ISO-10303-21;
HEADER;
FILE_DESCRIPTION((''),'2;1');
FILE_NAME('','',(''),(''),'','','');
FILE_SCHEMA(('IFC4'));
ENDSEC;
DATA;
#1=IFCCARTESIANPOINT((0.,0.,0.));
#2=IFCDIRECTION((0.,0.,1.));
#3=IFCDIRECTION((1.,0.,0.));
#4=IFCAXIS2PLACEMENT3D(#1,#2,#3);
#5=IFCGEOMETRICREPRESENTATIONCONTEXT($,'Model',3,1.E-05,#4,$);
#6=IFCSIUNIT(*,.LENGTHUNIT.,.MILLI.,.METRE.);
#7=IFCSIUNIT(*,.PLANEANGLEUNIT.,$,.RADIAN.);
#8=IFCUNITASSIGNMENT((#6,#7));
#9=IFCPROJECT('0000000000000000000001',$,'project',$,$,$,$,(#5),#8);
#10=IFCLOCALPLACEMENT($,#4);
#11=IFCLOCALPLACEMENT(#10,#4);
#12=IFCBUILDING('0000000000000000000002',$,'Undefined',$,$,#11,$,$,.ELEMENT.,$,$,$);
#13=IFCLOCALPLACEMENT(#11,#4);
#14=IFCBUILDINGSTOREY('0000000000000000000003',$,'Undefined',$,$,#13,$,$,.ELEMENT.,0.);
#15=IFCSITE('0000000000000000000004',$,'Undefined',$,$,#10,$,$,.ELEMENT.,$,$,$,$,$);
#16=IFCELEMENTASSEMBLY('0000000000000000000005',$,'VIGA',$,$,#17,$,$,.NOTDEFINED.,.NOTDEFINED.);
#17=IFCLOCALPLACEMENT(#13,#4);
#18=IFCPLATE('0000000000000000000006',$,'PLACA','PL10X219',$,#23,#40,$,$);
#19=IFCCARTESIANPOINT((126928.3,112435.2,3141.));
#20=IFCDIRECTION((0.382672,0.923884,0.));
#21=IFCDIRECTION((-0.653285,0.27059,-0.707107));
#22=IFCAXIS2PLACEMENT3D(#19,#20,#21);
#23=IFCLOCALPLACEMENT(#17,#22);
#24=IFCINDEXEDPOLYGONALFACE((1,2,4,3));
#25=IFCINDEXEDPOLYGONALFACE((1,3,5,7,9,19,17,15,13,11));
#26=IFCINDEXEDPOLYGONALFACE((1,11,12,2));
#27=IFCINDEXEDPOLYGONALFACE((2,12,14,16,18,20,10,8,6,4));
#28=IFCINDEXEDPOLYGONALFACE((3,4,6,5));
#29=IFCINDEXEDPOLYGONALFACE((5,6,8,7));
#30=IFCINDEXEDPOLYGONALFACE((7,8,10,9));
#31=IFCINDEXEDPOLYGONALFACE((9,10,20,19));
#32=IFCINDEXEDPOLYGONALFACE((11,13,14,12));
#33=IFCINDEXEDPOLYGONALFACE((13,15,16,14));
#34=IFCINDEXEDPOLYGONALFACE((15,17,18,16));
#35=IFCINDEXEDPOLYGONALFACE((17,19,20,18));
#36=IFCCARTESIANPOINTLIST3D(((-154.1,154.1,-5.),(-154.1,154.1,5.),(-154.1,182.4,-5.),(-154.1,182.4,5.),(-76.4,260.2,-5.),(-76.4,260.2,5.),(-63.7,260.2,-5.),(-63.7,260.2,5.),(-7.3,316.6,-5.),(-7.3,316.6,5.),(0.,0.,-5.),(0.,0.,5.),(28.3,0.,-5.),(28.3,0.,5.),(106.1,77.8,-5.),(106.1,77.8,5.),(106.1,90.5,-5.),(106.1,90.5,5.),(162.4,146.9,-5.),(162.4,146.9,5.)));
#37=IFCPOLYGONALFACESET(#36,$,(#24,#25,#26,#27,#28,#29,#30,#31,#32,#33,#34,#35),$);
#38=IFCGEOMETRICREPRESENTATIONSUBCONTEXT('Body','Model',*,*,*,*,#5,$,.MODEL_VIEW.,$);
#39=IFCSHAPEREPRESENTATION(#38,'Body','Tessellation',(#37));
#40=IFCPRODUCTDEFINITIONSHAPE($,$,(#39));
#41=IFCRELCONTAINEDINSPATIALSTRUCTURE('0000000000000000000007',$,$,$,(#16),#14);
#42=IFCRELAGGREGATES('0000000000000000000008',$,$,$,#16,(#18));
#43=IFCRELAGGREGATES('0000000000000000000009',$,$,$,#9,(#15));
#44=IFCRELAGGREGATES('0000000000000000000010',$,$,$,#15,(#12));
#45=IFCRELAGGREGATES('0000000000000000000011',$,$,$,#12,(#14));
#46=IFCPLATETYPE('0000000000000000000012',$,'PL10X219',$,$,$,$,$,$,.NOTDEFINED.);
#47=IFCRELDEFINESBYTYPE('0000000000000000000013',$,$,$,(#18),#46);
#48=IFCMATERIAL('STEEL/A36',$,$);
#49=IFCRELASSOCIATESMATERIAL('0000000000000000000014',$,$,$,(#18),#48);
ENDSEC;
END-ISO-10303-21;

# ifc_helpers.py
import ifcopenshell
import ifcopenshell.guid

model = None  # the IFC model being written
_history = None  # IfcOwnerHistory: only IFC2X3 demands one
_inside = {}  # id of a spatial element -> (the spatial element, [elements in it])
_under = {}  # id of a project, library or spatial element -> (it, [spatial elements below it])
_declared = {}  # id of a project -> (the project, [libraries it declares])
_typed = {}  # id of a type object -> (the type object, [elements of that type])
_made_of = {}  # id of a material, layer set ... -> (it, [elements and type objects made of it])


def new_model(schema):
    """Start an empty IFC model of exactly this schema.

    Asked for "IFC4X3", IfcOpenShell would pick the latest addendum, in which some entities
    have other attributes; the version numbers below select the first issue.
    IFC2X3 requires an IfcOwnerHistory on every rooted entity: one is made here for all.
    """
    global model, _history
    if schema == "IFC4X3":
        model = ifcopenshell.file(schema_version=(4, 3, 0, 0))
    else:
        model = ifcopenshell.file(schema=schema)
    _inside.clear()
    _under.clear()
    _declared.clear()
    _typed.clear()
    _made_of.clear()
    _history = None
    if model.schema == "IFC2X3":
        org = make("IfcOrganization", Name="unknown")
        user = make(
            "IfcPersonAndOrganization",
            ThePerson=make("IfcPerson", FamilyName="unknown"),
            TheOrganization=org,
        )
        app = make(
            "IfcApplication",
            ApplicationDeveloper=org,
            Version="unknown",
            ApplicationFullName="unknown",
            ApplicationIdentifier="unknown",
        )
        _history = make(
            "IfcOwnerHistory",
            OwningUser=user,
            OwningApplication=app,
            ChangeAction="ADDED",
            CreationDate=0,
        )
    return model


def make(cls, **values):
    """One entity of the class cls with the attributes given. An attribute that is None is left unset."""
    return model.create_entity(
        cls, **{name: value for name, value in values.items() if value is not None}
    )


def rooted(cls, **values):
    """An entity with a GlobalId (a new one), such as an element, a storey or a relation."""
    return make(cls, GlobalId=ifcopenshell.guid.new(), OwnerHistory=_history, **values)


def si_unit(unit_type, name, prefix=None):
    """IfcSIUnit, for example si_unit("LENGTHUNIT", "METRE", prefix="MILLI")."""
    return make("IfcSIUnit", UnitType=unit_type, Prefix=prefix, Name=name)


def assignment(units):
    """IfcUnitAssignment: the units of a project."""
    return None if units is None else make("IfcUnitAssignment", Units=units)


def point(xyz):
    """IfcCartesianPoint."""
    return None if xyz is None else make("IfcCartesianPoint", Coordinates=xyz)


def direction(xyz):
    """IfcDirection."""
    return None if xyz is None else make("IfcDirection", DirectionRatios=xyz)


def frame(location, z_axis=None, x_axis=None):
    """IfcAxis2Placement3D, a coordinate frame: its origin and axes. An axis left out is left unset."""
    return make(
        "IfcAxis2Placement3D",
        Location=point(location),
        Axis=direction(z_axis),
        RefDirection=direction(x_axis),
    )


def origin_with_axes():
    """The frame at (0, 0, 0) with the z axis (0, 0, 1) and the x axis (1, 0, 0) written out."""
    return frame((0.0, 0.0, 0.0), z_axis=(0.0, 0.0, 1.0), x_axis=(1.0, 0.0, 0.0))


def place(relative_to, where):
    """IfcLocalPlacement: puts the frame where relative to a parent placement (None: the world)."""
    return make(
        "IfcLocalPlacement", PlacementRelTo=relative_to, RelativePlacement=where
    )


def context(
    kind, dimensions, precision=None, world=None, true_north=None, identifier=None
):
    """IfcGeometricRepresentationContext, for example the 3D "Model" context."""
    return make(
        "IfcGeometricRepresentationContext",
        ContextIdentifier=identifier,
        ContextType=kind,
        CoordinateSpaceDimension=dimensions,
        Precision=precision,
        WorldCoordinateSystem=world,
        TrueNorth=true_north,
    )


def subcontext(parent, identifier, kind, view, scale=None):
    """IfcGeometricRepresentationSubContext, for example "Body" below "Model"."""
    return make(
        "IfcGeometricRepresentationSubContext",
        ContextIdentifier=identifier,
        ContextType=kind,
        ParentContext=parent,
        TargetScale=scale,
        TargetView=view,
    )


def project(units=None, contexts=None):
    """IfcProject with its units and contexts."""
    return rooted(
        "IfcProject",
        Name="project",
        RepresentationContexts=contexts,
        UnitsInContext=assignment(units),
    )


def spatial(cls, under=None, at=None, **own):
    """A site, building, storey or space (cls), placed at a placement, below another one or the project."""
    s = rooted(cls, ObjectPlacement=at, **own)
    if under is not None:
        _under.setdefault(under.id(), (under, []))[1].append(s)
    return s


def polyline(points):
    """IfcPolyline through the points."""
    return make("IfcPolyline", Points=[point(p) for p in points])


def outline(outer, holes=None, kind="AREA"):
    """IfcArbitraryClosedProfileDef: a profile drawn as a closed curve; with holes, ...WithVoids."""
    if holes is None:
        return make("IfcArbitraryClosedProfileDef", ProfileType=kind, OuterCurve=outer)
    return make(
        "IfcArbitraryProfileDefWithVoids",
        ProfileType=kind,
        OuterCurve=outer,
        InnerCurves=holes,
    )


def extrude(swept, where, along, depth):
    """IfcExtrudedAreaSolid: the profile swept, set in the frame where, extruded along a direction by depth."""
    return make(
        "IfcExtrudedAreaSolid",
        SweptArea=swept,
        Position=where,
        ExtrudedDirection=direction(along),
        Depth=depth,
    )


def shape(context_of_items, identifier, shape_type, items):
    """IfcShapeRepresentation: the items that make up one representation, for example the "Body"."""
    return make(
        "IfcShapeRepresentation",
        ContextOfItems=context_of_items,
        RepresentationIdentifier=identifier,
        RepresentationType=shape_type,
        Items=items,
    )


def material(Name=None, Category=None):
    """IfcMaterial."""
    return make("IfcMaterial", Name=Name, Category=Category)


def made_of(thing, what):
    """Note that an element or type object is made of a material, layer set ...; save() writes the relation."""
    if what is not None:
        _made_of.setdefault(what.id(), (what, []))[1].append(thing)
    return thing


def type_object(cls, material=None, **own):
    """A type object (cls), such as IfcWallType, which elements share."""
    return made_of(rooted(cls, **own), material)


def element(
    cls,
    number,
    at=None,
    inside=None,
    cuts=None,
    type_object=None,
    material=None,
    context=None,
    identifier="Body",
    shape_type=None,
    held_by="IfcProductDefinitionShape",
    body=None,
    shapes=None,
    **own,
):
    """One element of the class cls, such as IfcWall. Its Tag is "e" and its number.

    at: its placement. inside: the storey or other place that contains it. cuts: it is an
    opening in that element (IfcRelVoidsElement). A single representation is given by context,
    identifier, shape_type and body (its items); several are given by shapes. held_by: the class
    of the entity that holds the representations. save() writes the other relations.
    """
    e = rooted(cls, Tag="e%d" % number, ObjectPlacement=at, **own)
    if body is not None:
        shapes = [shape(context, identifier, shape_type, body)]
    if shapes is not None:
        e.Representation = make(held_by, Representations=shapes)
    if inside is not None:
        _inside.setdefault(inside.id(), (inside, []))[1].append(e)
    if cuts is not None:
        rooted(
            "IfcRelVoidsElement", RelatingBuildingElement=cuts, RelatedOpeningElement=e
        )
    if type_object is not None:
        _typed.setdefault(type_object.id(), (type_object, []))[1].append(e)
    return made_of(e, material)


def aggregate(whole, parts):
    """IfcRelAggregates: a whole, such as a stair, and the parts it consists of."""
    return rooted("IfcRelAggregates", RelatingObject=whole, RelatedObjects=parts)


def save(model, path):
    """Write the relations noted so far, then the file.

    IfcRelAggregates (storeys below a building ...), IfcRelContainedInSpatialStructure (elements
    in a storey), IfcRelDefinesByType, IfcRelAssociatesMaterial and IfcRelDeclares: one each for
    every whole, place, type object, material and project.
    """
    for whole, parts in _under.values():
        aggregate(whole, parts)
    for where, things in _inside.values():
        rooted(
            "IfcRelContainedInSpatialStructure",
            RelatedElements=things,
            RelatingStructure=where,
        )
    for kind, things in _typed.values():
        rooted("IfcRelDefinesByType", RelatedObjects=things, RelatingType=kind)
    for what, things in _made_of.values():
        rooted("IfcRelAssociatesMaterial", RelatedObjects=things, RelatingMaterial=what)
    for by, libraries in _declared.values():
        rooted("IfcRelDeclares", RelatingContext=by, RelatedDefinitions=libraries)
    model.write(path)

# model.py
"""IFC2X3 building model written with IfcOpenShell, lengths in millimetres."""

from ifc_helpers import new_model, si_unit, frame, origin_with_axes, place, context, subcontext, project, spatial, polyline, outline, extrude, material, type_object, element, aggregate, save


model = new_model("IFC2X3")

# Units and contexts
model_context = context("Model", 3, precision=1e-05, world=origin_with_axes())
body_context = subcontext(model_context, "Body", "Model", "MODEL_VIEW")
ifc_project = project(units=[si_unit("LENGTHUNIT", "METRE", prefix="MILLI"), si_unit("PLANEANGLEUNIT", "RADIAN")], contexts=[model_context])

# Site, building, storey
site_placement = place(None, origin_with_axes())
site = spatial("IfcSite", under=ifc_project, at=site_placement, Name="Undefined", CompositionType="ELEMENT")
building_placement = place(site_placement, origin_with_axes())
building = spatial("IfcBuilding", under=site, at=building_placement, Name="Undefined", CompositionType="ELEMENT")
storey_placement = place(building_placement, origin_with_axes())
storey = spatial("IfcBuildingStorey", under=building, at=storey_placement, Name="Undefined", CompositionType="ELEMENT", Elevation=0.0)

# Element assembly
assembly_1_placement = place(storey_placement, origin_with_axes())
assembly_1 = element("IfcElementAssembly", 1, at=assembly_1_placement, inside=storey, Name="VIGA", AssemblyPlace="NOTDEFINED", PredefinedType="NOTDEFINED")
ifc_material_1 = material(Name="STEEL/A36")

# Plate
plate_type_1 = type_object("IfcPlateType", Name="PL10X219", PredefinedType="NOTDEFINED")
plate_1_placement = place(assembly_1_placement, frame((126928.3, 112435.2, 3141.0), z_axis=(0.382672, 0.923884, 0.0), x_axis=(-0.653285, 0.27059, -0.707107)))
plate_1 = element("IfcPlate", 2, at=plate_1_placement, type_object=plate_type_1, material=ifc_material_1, Name="PLACA", Description="PL10X219", context=body_context, shape_type="SweptSolid", body=[
    extrude(outline(polyline([(0.0, 0.0), (28.3, 0.0), (106.1, 77.8), (106.1, 77.8), (106.1, 90.5), (162.4, 146.9), (-7.3, 316.6), (-63.7, 260.2), (-76.4, 260.2), (-76.4, 260.2), (-154.1, 182.4), (-154.1, 154.1), (0.0, 0.0)])), frame((0.0, 0.0, -5.0), z_axis=(0.0, 0.0, 1.0), x_axis=(1.0, 0.0, 0.0)), (0.0, 0.0, 1.0), 10.0),
])

aggregate(assembly_1, [plate_1])

save(model, "model.ifc")
